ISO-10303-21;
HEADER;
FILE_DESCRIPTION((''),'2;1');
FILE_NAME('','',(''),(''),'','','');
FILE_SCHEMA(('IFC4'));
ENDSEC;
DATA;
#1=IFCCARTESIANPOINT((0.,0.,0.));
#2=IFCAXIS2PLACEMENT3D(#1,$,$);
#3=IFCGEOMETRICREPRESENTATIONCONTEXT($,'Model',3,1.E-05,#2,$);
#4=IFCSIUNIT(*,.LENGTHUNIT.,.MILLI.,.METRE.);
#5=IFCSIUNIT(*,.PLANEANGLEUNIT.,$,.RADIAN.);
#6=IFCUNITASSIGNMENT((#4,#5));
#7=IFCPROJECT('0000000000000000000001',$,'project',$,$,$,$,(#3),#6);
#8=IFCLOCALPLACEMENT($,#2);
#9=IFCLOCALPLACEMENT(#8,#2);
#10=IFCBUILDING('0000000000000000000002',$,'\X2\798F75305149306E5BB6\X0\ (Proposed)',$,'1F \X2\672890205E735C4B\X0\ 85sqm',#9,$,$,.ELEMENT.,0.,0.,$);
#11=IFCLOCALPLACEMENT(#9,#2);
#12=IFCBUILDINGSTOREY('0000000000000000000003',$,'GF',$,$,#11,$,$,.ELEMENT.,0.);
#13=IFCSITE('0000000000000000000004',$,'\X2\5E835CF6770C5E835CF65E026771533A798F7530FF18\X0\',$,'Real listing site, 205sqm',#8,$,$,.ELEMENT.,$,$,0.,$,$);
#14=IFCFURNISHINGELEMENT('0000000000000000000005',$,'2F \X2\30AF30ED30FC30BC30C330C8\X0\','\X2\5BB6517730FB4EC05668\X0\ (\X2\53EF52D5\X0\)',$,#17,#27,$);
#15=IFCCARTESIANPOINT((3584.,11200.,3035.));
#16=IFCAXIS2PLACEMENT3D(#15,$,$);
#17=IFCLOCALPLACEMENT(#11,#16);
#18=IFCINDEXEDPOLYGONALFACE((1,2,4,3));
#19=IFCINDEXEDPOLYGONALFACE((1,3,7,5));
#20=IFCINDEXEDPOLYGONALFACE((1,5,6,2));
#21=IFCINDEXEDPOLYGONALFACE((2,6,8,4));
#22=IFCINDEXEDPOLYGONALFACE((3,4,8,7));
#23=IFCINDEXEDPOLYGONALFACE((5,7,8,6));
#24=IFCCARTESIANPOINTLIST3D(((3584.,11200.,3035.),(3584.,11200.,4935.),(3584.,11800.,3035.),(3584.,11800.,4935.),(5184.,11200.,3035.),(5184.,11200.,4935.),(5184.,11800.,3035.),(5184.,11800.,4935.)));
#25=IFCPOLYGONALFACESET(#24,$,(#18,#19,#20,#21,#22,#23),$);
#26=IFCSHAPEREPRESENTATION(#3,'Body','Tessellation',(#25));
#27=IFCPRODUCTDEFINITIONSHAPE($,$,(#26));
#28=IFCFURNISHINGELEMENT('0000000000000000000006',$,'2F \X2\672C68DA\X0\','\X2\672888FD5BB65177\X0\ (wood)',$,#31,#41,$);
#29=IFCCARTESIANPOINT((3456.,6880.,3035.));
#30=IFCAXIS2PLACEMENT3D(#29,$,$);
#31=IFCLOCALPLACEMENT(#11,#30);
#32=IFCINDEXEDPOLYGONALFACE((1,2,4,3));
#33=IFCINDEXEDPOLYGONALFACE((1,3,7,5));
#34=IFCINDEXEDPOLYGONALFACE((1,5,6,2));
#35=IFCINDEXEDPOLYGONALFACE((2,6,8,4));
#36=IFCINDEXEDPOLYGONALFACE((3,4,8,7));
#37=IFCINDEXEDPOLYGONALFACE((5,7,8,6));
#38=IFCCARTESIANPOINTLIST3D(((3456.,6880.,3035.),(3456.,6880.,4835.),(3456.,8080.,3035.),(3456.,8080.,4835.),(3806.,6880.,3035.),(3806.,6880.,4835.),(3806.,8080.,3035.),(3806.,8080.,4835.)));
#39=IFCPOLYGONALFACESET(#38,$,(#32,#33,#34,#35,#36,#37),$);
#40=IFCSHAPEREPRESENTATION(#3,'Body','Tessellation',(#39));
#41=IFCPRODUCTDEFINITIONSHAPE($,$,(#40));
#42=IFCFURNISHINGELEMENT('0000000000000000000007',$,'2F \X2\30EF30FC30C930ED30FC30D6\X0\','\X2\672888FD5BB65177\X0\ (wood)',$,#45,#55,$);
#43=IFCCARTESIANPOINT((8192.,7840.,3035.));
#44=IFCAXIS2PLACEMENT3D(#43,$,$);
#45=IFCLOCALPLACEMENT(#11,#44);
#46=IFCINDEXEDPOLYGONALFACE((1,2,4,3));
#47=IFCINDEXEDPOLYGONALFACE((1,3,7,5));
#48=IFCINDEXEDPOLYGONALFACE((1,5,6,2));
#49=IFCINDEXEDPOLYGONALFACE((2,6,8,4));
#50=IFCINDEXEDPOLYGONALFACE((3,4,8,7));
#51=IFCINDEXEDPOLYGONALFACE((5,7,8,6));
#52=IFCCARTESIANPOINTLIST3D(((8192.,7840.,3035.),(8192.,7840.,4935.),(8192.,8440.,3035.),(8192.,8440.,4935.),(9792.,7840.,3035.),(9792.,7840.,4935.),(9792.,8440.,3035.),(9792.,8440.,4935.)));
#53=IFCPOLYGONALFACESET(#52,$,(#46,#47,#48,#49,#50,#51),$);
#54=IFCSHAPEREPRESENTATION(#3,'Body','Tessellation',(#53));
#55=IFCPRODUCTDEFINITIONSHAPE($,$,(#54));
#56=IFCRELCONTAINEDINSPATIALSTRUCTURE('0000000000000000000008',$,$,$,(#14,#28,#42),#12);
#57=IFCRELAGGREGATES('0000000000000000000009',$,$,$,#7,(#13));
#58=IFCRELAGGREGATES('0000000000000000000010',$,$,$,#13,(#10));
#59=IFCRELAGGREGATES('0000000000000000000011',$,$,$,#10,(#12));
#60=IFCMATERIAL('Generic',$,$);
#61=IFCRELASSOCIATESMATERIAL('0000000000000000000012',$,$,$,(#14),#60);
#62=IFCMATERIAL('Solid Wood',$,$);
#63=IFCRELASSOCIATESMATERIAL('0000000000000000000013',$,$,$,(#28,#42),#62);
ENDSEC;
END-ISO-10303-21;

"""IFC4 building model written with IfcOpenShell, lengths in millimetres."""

from ifc_helpers import new_model, si_unit, frame, frame_2d, origin, place, context, project, spatial, rectangle, extrude, material, element, save


model = new_model("IFC4")

# Units and contexts
model_context = context("Model", 3, precision=1e-05, world=origin())
ifc_project = project(units=[si_unit("LENGTHUNIT", "METRE", prefix="MILLI"), si_unit("PLANEANGLEUNIT", "RADIAN")], contexts=[model_context])

# Site, building, storey
site_placement = place(None, origin())
site = spatial("IfcSite", under=ifc_project, at=site_placement, Name="広島県広島市東区福田８", ObjectType="Real listing site, 205sqm", CompositionType="ELEMENT", RefElevation=0.0)
building_placement = place(site_placement, origin())
building = spatial("IfcBuilding", under=site, at=building_placement, Name="福田光の家 (Proposed)", ObjectType="1F 木造平屋 85sqm", CompositionType="ELEMENT", ElevationOfRefHeight=0.0, ElevationOfTerrain=0.0)
storey_placement = place(building_placement, origin())
storey = spatial("IfcBuildingStorey", under=building, at=storey_placement, Name="GF", CompositionType="ELEMENT", Elevation=0.0)

# Shared definitions
ifc_material_1 = material(Name="Solid Wood")

# Shared definitions
ifc_material_2 = material(Name="Generic")

# Furnishing elements
furnishing_1_placement = place(storey_placement, frame((3584.0, 11200.0, 3035.0)))
element("IfcFurnishingElement", 1, at=furnishing_1_placement, inside=storey, material=ifc_material_2, Name="2F クローゼット", Description="家具・什器 (可動)", context=model_context, shape_type="SweptSolid", body=[
    extrude(rectangle(XDim=1600.0, YDim=600.0, at=frame_2d((800.0, 300.0))), frame((3584.0, 11200.0, 3035.0)), (0.0, 0.0, 1.0), 1900.0),
])
furnishing_2_placement = place(storey_placement, frame((3456.0, 6880.0, 3035.0)))
element("IfcFurnishingElement", 2, at=furnishing_2_placement, inside=storey, material=ifc_material_1, Name="2F 本棚", Description="木製家具 (wood)", context=model_context, shape_type="SweptSolid", body=[
    extrude(rectangle(XDim=350.0, YDim=1200.0, at=frame_2d((175.0, 600.0))), frame((3456.0, 6880.0, 3035.0)), (0.0, 0.0, 1.0), 1800.0),
])
furnishing_3_placement = place(storey_placement, frame((8192.0, 7840.0, 3035.0)))
element("IfcFurnishingElement", 3, at=furnishing_3_placement, inside=storey, material=ifc_material_1, Name="2F ワードローブ", Description="木製家具 (wood)", context=model_context, shape_type="SweptSolid", body=[
    extrude(rectangle(XDim=1600.0, YDim=600.0, at=frame_2d((800.0, 300.0))), frame((8192.0, 7840.0, 3035.0)), (0.0, 0.0, 1.0), 1900.0),
])

save(model, "model.ifc")
